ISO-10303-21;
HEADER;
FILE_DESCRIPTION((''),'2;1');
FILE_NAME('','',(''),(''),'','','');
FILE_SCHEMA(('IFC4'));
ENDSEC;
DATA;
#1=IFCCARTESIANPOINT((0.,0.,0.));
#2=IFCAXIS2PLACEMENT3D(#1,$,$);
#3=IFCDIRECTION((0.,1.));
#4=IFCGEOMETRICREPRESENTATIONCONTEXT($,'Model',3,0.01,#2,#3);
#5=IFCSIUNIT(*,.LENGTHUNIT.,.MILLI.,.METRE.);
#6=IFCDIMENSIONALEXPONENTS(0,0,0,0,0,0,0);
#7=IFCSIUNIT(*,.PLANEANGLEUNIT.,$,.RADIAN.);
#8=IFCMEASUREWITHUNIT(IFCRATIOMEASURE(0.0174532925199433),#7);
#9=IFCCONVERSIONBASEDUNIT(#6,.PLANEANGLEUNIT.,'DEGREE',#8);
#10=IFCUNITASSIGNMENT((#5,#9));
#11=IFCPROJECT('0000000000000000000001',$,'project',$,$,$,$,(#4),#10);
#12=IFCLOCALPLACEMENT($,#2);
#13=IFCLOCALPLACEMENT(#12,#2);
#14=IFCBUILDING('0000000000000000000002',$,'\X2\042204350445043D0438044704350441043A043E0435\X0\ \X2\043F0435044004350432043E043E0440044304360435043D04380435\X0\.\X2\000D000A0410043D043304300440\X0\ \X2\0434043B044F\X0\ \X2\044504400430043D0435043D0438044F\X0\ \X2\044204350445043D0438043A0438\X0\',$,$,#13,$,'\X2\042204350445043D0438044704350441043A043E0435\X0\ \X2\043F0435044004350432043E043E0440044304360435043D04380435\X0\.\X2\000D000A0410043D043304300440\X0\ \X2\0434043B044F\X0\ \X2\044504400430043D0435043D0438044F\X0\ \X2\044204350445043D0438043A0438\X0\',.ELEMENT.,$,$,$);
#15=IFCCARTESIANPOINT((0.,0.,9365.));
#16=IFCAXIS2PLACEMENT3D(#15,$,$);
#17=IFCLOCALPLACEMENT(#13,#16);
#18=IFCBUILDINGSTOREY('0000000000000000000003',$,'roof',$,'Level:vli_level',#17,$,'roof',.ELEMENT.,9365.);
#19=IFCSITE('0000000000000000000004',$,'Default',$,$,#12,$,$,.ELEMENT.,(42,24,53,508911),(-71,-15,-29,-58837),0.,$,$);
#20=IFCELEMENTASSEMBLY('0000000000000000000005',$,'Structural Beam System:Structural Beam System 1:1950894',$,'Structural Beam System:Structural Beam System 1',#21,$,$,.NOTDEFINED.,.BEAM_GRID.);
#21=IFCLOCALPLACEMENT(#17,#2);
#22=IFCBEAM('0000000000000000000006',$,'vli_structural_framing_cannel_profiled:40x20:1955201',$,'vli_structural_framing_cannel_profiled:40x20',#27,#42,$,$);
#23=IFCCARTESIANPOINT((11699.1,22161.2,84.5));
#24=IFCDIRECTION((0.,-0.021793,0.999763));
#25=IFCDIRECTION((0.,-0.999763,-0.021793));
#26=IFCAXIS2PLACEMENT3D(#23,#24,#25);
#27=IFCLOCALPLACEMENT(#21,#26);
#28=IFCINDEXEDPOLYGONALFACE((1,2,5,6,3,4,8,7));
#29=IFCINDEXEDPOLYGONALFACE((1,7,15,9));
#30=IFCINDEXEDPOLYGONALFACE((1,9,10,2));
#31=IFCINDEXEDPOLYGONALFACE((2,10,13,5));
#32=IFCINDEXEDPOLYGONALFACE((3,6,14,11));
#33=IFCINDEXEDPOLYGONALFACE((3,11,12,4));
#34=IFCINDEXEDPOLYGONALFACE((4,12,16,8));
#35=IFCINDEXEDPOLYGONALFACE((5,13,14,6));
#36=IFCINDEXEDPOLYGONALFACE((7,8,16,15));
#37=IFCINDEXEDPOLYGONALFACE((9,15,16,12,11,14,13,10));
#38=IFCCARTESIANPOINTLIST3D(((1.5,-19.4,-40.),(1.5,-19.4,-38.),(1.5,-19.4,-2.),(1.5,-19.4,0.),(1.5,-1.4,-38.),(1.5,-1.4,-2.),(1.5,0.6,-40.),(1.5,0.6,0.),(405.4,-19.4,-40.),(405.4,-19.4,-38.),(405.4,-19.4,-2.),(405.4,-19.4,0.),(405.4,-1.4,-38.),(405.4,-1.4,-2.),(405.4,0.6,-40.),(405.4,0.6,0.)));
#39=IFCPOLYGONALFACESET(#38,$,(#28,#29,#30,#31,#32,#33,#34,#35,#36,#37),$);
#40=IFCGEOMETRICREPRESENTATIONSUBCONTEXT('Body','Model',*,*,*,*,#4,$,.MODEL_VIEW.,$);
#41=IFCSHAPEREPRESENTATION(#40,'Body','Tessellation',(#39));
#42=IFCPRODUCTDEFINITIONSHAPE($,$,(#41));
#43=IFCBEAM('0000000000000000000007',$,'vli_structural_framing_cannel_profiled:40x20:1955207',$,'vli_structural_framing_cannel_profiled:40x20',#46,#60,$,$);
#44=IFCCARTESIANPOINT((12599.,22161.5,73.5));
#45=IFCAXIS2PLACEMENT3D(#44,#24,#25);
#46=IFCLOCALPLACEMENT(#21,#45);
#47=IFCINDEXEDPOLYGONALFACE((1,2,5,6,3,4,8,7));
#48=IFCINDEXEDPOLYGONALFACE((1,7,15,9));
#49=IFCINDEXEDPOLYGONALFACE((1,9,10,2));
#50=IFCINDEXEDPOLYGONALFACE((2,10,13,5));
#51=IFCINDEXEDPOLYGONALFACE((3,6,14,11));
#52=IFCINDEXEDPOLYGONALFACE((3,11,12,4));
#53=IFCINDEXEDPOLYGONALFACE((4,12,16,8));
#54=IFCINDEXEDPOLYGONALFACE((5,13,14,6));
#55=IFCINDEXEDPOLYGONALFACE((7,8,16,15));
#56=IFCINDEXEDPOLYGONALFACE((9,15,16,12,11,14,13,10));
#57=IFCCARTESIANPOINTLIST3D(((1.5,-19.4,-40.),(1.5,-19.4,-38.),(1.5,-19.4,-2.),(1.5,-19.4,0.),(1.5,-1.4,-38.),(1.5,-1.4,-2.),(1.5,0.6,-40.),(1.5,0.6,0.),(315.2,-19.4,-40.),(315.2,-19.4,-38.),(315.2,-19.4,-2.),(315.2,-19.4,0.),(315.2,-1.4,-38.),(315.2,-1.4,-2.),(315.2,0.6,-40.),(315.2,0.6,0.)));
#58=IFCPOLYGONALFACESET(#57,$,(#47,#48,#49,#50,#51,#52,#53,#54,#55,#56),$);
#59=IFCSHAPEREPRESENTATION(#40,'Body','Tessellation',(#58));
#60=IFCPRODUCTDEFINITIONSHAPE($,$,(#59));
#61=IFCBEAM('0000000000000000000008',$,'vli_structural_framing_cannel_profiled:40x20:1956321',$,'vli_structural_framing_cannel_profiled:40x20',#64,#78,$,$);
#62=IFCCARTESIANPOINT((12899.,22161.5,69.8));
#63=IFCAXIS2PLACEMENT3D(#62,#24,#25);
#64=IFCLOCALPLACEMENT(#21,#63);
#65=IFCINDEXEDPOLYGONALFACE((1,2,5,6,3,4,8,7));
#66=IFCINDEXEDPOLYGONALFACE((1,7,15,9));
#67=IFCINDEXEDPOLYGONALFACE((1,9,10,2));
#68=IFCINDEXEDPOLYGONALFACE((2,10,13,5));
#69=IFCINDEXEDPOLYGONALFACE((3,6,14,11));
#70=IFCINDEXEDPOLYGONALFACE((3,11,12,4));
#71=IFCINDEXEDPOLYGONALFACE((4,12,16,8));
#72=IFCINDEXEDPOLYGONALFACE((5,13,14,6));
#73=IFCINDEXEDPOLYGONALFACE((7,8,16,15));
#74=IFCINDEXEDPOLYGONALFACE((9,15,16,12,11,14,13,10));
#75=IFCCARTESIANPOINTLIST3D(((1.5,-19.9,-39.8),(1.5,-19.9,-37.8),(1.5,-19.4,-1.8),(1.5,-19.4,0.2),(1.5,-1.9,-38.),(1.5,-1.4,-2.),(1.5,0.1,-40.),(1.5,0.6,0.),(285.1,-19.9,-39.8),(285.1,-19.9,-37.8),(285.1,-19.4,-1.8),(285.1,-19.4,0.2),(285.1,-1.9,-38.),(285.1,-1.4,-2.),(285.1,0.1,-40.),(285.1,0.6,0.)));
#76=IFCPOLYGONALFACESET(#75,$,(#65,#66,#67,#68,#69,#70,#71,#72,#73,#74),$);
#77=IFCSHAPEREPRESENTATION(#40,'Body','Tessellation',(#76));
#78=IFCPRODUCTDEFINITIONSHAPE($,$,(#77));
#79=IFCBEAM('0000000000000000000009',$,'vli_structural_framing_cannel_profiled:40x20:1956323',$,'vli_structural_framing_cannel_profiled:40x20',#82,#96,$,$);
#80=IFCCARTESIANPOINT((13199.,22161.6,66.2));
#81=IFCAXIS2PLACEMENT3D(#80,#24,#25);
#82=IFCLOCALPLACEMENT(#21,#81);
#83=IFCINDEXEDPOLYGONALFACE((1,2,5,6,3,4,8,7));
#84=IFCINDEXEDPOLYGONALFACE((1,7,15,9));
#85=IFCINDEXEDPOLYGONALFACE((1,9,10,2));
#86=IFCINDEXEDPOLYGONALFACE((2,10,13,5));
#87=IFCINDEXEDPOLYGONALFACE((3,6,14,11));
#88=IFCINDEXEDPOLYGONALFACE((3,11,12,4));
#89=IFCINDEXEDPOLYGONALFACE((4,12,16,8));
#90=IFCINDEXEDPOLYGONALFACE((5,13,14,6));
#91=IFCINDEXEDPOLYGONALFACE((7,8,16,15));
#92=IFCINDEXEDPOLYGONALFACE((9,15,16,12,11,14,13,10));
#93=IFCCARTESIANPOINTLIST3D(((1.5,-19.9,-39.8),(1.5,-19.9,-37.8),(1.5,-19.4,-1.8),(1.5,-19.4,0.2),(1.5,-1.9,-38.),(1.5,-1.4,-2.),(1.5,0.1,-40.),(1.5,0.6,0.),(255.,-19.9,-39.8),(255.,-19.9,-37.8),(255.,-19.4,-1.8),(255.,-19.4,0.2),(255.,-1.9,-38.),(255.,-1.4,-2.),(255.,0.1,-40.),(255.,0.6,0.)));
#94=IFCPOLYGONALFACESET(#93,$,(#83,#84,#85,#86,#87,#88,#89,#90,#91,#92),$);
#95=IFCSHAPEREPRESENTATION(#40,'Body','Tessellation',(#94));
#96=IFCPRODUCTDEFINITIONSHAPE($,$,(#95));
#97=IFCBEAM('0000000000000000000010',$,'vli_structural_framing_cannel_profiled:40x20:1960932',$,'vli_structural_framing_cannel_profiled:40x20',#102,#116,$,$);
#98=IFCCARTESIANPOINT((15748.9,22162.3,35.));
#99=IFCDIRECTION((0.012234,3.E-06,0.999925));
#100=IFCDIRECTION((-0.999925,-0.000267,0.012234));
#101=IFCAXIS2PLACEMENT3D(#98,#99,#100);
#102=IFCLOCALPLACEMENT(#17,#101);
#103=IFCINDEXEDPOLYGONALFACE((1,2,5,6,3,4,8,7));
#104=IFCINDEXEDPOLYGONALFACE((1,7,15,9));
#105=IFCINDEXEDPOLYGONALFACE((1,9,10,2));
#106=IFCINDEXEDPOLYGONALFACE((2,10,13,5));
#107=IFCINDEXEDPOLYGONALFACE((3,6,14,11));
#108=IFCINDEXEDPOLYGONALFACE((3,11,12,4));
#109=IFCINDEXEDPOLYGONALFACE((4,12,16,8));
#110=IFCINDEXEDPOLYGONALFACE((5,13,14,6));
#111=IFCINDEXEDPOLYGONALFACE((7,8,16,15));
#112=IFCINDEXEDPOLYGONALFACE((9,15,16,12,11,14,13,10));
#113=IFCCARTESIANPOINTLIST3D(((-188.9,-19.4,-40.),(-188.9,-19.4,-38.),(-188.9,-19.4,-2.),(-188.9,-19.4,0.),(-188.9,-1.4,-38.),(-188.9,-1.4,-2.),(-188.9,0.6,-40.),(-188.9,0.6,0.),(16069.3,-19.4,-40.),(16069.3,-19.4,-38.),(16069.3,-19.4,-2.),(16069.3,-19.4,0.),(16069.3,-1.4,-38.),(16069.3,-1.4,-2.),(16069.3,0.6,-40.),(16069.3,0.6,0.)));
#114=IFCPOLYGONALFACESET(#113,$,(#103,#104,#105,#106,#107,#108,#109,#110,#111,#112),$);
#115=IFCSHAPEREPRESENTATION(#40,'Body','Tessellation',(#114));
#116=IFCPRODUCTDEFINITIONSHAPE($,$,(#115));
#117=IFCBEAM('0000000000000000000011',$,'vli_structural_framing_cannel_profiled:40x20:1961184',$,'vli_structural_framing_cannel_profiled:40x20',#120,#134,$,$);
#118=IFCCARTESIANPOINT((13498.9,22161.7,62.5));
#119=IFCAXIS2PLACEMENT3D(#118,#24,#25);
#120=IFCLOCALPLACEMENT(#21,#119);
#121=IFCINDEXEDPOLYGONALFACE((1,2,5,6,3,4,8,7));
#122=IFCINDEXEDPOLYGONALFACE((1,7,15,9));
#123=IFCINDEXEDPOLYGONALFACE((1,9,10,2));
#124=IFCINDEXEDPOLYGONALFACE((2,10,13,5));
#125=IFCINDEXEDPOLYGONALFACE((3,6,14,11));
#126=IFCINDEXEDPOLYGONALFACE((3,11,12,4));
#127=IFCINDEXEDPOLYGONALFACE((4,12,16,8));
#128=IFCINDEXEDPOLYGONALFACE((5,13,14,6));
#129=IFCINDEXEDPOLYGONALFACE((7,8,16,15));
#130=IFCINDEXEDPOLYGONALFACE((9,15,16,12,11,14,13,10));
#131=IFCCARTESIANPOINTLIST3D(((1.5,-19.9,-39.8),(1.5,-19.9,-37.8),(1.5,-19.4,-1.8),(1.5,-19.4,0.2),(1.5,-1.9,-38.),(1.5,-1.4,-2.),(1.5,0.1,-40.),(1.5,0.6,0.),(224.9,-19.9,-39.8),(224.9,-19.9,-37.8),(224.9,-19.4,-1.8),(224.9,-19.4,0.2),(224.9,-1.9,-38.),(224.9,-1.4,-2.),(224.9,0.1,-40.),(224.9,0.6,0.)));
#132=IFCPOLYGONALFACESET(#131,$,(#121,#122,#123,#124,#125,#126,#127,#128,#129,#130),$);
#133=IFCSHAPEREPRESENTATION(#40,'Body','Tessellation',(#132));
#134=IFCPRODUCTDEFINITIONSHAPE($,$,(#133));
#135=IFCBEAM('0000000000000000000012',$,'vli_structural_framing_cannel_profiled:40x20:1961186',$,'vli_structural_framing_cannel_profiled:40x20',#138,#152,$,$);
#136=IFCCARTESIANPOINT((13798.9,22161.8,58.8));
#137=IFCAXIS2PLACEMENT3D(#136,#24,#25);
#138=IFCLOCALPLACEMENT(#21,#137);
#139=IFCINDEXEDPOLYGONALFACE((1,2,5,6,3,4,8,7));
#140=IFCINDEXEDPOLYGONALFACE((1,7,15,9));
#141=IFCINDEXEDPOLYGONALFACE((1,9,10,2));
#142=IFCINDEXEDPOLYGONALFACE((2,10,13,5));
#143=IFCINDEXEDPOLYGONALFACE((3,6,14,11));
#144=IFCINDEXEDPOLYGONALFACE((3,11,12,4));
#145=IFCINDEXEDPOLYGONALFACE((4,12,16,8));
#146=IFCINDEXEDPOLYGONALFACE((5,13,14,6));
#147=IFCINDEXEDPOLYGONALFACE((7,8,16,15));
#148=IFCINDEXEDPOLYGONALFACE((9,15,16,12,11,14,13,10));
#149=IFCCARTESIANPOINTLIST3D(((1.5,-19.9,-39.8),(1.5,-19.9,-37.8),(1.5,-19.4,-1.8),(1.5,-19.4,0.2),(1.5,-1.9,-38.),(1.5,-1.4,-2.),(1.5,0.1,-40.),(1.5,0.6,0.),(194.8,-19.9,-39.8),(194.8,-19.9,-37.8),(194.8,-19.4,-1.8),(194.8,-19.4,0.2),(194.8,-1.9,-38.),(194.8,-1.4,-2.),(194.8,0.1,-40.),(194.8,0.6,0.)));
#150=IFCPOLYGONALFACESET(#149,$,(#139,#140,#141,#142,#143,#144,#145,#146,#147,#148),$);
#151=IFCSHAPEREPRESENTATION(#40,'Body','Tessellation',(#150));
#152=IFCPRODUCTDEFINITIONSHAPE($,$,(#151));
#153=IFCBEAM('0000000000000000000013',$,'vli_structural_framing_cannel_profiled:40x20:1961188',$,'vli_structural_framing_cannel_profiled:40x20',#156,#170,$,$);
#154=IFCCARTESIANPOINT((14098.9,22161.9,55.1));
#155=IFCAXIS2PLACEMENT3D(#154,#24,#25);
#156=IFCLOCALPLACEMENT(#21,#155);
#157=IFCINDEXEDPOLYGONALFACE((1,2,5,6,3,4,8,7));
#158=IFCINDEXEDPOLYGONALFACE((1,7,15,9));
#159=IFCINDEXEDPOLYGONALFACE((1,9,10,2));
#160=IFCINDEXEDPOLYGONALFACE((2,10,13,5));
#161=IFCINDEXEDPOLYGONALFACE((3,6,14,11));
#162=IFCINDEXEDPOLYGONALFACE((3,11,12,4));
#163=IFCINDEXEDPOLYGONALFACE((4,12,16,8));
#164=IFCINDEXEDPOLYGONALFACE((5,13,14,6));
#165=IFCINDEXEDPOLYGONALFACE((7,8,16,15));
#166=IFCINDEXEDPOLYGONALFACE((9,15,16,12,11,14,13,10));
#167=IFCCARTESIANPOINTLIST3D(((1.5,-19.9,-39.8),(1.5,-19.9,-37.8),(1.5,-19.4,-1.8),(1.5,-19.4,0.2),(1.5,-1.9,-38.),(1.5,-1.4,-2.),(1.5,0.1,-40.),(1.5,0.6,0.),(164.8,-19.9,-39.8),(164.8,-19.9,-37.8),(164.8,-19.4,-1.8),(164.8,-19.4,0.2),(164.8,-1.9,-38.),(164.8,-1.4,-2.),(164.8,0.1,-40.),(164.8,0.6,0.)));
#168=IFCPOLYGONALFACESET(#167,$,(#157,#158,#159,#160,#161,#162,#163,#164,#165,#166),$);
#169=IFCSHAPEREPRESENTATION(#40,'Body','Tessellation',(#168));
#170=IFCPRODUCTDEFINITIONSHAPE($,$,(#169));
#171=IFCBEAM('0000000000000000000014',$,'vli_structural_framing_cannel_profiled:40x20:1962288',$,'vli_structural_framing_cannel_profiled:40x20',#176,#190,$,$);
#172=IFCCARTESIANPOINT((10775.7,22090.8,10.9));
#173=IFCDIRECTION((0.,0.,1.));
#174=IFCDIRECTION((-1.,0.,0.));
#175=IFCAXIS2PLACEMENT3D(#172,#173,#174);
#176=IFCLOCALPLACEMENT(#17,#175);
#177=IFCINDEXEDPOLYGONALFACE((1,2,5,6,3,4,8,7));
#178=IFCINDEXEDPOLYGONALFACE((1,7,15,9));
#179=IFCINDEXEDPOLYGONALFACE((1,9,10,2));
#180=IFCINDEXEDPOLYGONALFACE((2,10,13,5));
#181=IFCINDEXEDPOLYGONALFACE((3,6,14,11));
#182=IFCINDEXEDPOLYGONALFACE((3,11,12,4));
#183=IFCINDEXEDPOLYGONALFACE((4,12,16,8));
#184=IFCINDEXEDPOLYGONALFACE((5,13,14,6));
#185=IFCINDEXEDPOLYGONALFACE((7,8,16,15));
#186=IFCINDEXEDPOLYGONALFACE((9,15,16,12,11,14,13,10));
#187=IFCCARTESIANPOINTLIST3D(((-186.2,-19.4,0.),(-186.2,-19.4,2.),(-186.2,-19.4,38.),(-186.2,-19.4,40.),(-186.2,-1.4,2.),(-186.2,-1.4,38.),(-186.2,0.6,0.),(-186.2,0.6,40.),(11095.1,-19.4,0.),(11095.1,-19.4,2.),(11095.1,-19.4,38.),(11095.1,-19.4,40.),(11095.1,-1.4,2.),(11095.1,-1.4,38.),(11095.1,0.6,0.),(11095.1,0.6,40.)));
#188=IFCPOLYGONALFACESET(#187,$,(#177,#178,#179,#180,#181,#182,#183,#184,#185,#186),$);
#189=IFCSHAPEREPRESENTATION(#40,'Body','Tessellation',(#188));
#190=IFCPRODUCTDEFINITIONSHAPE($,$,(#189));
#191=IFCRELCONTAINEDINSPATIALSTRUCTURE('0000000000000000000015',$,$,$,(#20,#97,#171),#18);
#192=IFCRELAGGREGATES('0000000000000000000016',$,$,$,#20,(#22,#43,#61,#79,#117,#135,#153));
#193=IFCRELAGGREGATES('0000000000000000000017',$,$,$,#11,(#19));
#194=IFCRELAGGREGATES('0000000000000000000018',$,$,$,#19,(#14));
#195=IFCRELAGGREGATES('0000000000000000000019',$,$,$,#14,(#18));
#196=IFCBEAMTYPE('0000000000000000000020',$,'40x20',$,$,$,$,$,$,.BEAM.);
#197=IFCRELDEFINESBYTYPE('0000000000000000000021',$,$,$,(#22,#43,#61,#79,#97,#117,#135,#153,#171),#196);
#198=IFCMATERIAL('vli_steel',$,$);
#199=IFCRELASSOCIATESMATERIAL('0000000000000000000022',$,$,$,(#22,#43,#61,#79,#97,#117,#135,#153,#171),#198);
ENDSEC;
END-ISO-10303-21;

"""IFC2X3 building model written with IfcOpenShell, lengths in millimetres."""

from ifc_helpers import new_model, entity, si_unit, converted_unit, direction, frame, origin, place, context, subcontext, project, spatial, polyline, outline, extrude, material, type_object, element, aggregate, save


model = new_model("IFC2X3")

# Units and contexts
model_context = context("Model", 3, precision=0.01, world=origin(), true_north=direction((0.0, 1.0)))
body_context = subcontext(model_context, "Body", "Model", "MODEL_VIEW")
ifc_project = project(units=[si_unit("LENGTHUNIT", "METRE", prefix="MILLI"), converted_unit("PLANEANGLEUNIT", "DEGREE", entity("IfcRatioMeasure", 0.0174532925199433), si_unit("PLANEANGLEUNIT", "RADIAN"), dimensions=[0, 0, 0, 0, 0, 0, 0])], contexts=[model_context])

# Site, building, storey
site_placement = place(None, origin())
site = spatial("IfcSite", under=ifc_project, at=site_placement, Name="Default", CompositionType="ELEMENT", RefLatitude=(42, 24, 53, 508911), RefLongitude=(-71, -15, -29, -58837), RefElevation=0.0)
building_placement = place(site_placement, origin())
building = spatial("IfcBuilding", under=site, at=building_placement, Name="Техническое перевооружение.\r\nАнгар для хранения техники", LongName="Техническое перевооружение.\r\nАнгар для хранения техники", CompositionType="ELEMENT")
storey_placement = place(building_placement, frame((0.0, 0.0, 9365.0)))
storey = spatial("IfcBuildingStorey", under=building, at=storey_placement, Name="roof", ObjectType="Level:vli_level", LongName="roof", CompositionType="ELEMENT", Elevation=9365.0)

# Element assembly, beams
ifc_material = material(Name="vli_steel")
beam_type = type_object("IfcBeamType", Name="40x20", PredefinedType="BEAM")
assembly_1_placement = place(storey_placement, origin())
assembly_1 = element("IfcElementAssembly", 1, at=assembly_1_placement, inside=storey, Name="Structural Beam System:Structural Beam System 1:1950894", ObjectType="Structural Beam System:Structural Beam System 1", AssemblyPlace="NOTDEFINED", PredefinedType="BEAM_GRID")
beam_1_placement = place(assembly_1_placement, frame((11699.1, 22161.2, 84.5), z_axis=(0.0, -0.021793, 0.999763), x_axis=(0.0, -0.999763, -0.021793)))
beam_1 = element("IfcBeam", 2, at=beam_1_placement, type_object=beam_type, material=ifc_material, Name="vli_structural_framing_cannel_profiled:40x20:1955201", ObjectType="vli_structural_framing_cannel_profiled:40x20", context=body_context, shape_type="SweptSolid", body=[
    extrude(outline(polyline([(-20.0, -9.5), (-18.0, -9.5), (-18.0, 8.5), (18.0, 8.5), (18.0, -9.5), (20.0, -9.5), (20.0, 10.5), (-20.0, 10.5), (-20.0, -9.5)])), frame((1.5, -9.9, -20.0), z_axis=(1.0, 0.0, 0.0), x_axis=(0.0, 0.0, -1.0)), (0.0, 0.0, 1.0), 403.9),
])
beam_2_placement = place(assembly_1_placement, frame((12599.0, 22161.5, 73.5), z_axis=(0.0, -0.021793, 0.999763), x_axis=(0.0, -0.999763, -0.021793)))
beam_2 = element("IfcBeam", 3, at=beam_2_placement, type_object=beam_type, material=ifc_material, Name="vli_structural_framing_cannel_profiled:40x20:1955207", ObjectType="vli_structural_framing_cannel_profiled:40x20", context=body_context, shape_type="SweptSolid", body=[
    extrude(outline(polyline([(-20.0, -9.5), (-18.0, -9.5), (-18.0, 8.5), (18.0, 8.5), (18.0, -9.5), (20.0, -9.5), (20.0, 10.5), (-20.0, 10.5), (-20.0, -9.5)])), frame((1.5, -9.9, -20.0), z_axis=(1.0, 0.0, 0.0), x_axis=(0.0, 0.0, -1.0)), (0.0, 0.0, 1.0), 313.7),
])
beam_3_placement = place(assembly_1_placement, frame((12899.0, 22161.5, 69.8), z_axis=(0.0, -0.021793, 0.999763), x_axis=(0.0, -0.999763, -0.021793)))
beam_3 = element("IfcBeam", 4, at=beam_3_placement, type_object=beam_type, material=ifc_material, Name="vli_structural_framing_cannel_profiled:40x20:1956321", ObjectType="vli_structural_framing_cannel_profiled:40x20", context=body_context, shape_type="SweptSolid", body=[
    extrude(outline(polyline([(-10.5, -20.0), (9.5, -20.0), (9.5, -18.0), (-8.5, -18.0), (-8.5, 18.0), (9.5, 18.0), (9.5, 20.0), (-10.5, 20.0), (-10.5, -20.0)])), frame((1.5, -10.1, -19.9), z_axis=(1.0, 0.0, 0.0), x_axis=(0.0, -0.999925, 0.012237)), (0.0, 0.0, 1.0), 283.6),
])
beam_4_placement = place(assembly_1_placement, frame((13199.0, 22161.6, 66.2), z_axis=(0.0, -0.021793, 0.999763), x_axis=(0.0, -0.999763, -0.021793)))
beam_4 = element("IfcBeam", 5, at=beam_4_placement, type_object=beam_type, material=ifc_material, Name="vli_structural_framing_cannel_profiled:40x20:1956323", ObjectType="vli_structural_framing_cannel_profiled:40x20", context=body_context, shape_type="SweptSolid", body=[
    extrude(outline(polyline([(-10.5, -20.0), (9.5, -20.0), (9.5, -18.0), (-8.5, -18.0), (-8.5, 18.0), (9.5, 18.0), (9.5, 20.0), (-10.5, 20.0), (-10.5, -20.0)])), frame((1.5, -10.1, -19.9), z_axis=(1.0, 0.0, 0.0), x_axis=(0.0, -0.999925, 0.012237)), (0.0, 0.0, 1.0), 253.5),
])

# Beams
beam_5_placement = place(storey_placement, frame((15748.9, 22162.3, 35.0), z_axis=(0.012234, 0.000003, 0.999925), x_axis=(-0.999925, -0.000267, 0.012234)))
element("IfcBeam", 6, at=beam_5_placement, inside=storey, type_object=beam_type, material=ifc_material, Name="vli_structural_framing_cannel_profiled:40x20:1960932", ObjectType="vli_structural_framing_cannel_profiled:40x20", context=body_context, shape_type="SweptSolid", body=[
    extrude(outline(polyline([(-20.0, -9.5), (-18.0, -9.5), (-18.0, 8.5), (18.0, 8.5), (18.0, -9.5), (20.0, -9.5), (20.0, 10.5), (-20.0, 10.5), (-20.0, -9.5)])), frame((-188.9, -9.9, -20.0), z_axis=(1.0, 0.0, 0.0), x_axis=(0.0, 0.0, -1.0)), (0.0, 0.0, 1.0), 16258.2),
])
beam_6_placement = place(assembly_1_placement, frame((13498.9, 22161.7, 62.5), z_axis=(0.0, -0.021793, 0.999763), x_axis=(0.0, -0.999763, -0.021793)))
beam_6 = element("IfcBeam", 7, at=beam_6_placement, type_object=beam_type, material=ifc_material, Name="vli_structural_framing_cannel_profiled:40x20:1961184", ObjectType="vli_structural_framing_cannel_profiled:40x20", context=body_context, shape_type="SweptSolid", body=[
    extrude(outline(polyline([(-10.5, -20.0), (9.5, -20.0), (9.5, -18.0), (-8.5, -18.0), (-8.5, 18.0), (9.5, 18.0), (9.5, 20.0), (-10.5, 20.0), (-10.5, -20.0)])), frame((1.5, -10.1, -19.9), z_axis=(1.0, 0.0, 0.0), x_axis=(0.0, -0.999925, 0.012237)), (0.0, 0.0, 1.0), 223.5),
])
beam_7_placement = place(assembly_1_placement, frame((13798.9, 22161.8, 58.8), z_axis=(0.0, -0.021793, 0.999763), x_axis=(0.0, -0.999763, -0.021793)))
beam_7 = element("IfcBeam", 8, at=beam_7_placement, type_object=beam_type, material=ifc_material, Name="vli_structural_framing_cannel_profiled:40x20:1961186", ObjectType="vli_structural_framing_cannel_profiled:40x20", context=body_context, shape_type="SweptSolid", body=[
    extrude(outline(polyline([(-10.5, -20.0), (9.5, -20.0), (9.5, -18.0), (-8.5, -18.0), (-8.5, 18.0), (9.5, 18.0), (9.5, 20.0), (-10.5, 20.0), (-10.5, -20.0)])), frame((1.5, -10.1, -19.9), z_axis=(1.0, 0.0, 0.0), x_axis=(0.0, -0.999925, 0.012237)), (0.0, 0.0, 1.0), 193.4),
])
beam_8_placement = place(assembly_1_placement, frame((14098.9, 22161.9, 55.1), z_axis=(0.0, -0.021793, 0.999763), x_axis=(0.0, -0.999763, -0.021793)))
beam_8 = element("IfcBeam", 9, at=beam_8_placement, type_object=beam_type, material=ifc_material, Name="vli_structural_framing_cannel_profiled:40x20:1961188", ObjectType="vli_structural_framing_cannel_profiled:40x20", context=body_context, shape_type="SweptSolid", body=[
    extrude(outline(polyline([(-10.5, -20.0), (9.5, -20.0), (9.5, -18.0), (-8.5, -18.0), (-8.5, 18.0), (9.5, 18.0), (9.5, 20.0), (-10.5, 20.0), (-10.5, -20.0)])), frame((1.5, -10.1, -19.9), z_axis=(1.0, 0.0, 0.0), x_axis=(0.0, -0.999925, 0.012237)), (0.0, 0.0, 1.0), 163.3),
])
aggregate(assembly_1, [beam_1, beam_2, beam_3, beam_4, beam_6, beam_7, beam_8])
beam_9_placement = place(storey_placement, frame((10775.7, 22090.8, 10.9), z_axis=(0.0, 0.0, 1.0), x_axis=(-1.0, 0.0, 0.0)))
element("IfcBeam", 10, at=beam_9_placement, inside=storey, type_object=beam_type, material=ifc_material, Name="vli_structural_framing_cannel_profiled:40x20:1962288", ObjectType="vli_structural_framing_cannel_profiled:40x20", context=body_context, shape_type="SweptSolid", body=[
    extrude(outline(polyline([(-20.0, -9.5), (-18.0, -9.5), (-18.0, 8.5), (18.0, 8.5), (18.0, -9.5), (20.0, -9.5), (20.0, 10.5), (-20.0, 10.5), (-20.0, -9.5)])), frame((-186.2, -9.9, 20.0), z_axis=(1.0, 0.0, 0.0), x_axis=(0.0, 0.0, -1.0)), (0.0, 0.0, 1.0), 11281.3),
])

save(model, "model.ifc")
